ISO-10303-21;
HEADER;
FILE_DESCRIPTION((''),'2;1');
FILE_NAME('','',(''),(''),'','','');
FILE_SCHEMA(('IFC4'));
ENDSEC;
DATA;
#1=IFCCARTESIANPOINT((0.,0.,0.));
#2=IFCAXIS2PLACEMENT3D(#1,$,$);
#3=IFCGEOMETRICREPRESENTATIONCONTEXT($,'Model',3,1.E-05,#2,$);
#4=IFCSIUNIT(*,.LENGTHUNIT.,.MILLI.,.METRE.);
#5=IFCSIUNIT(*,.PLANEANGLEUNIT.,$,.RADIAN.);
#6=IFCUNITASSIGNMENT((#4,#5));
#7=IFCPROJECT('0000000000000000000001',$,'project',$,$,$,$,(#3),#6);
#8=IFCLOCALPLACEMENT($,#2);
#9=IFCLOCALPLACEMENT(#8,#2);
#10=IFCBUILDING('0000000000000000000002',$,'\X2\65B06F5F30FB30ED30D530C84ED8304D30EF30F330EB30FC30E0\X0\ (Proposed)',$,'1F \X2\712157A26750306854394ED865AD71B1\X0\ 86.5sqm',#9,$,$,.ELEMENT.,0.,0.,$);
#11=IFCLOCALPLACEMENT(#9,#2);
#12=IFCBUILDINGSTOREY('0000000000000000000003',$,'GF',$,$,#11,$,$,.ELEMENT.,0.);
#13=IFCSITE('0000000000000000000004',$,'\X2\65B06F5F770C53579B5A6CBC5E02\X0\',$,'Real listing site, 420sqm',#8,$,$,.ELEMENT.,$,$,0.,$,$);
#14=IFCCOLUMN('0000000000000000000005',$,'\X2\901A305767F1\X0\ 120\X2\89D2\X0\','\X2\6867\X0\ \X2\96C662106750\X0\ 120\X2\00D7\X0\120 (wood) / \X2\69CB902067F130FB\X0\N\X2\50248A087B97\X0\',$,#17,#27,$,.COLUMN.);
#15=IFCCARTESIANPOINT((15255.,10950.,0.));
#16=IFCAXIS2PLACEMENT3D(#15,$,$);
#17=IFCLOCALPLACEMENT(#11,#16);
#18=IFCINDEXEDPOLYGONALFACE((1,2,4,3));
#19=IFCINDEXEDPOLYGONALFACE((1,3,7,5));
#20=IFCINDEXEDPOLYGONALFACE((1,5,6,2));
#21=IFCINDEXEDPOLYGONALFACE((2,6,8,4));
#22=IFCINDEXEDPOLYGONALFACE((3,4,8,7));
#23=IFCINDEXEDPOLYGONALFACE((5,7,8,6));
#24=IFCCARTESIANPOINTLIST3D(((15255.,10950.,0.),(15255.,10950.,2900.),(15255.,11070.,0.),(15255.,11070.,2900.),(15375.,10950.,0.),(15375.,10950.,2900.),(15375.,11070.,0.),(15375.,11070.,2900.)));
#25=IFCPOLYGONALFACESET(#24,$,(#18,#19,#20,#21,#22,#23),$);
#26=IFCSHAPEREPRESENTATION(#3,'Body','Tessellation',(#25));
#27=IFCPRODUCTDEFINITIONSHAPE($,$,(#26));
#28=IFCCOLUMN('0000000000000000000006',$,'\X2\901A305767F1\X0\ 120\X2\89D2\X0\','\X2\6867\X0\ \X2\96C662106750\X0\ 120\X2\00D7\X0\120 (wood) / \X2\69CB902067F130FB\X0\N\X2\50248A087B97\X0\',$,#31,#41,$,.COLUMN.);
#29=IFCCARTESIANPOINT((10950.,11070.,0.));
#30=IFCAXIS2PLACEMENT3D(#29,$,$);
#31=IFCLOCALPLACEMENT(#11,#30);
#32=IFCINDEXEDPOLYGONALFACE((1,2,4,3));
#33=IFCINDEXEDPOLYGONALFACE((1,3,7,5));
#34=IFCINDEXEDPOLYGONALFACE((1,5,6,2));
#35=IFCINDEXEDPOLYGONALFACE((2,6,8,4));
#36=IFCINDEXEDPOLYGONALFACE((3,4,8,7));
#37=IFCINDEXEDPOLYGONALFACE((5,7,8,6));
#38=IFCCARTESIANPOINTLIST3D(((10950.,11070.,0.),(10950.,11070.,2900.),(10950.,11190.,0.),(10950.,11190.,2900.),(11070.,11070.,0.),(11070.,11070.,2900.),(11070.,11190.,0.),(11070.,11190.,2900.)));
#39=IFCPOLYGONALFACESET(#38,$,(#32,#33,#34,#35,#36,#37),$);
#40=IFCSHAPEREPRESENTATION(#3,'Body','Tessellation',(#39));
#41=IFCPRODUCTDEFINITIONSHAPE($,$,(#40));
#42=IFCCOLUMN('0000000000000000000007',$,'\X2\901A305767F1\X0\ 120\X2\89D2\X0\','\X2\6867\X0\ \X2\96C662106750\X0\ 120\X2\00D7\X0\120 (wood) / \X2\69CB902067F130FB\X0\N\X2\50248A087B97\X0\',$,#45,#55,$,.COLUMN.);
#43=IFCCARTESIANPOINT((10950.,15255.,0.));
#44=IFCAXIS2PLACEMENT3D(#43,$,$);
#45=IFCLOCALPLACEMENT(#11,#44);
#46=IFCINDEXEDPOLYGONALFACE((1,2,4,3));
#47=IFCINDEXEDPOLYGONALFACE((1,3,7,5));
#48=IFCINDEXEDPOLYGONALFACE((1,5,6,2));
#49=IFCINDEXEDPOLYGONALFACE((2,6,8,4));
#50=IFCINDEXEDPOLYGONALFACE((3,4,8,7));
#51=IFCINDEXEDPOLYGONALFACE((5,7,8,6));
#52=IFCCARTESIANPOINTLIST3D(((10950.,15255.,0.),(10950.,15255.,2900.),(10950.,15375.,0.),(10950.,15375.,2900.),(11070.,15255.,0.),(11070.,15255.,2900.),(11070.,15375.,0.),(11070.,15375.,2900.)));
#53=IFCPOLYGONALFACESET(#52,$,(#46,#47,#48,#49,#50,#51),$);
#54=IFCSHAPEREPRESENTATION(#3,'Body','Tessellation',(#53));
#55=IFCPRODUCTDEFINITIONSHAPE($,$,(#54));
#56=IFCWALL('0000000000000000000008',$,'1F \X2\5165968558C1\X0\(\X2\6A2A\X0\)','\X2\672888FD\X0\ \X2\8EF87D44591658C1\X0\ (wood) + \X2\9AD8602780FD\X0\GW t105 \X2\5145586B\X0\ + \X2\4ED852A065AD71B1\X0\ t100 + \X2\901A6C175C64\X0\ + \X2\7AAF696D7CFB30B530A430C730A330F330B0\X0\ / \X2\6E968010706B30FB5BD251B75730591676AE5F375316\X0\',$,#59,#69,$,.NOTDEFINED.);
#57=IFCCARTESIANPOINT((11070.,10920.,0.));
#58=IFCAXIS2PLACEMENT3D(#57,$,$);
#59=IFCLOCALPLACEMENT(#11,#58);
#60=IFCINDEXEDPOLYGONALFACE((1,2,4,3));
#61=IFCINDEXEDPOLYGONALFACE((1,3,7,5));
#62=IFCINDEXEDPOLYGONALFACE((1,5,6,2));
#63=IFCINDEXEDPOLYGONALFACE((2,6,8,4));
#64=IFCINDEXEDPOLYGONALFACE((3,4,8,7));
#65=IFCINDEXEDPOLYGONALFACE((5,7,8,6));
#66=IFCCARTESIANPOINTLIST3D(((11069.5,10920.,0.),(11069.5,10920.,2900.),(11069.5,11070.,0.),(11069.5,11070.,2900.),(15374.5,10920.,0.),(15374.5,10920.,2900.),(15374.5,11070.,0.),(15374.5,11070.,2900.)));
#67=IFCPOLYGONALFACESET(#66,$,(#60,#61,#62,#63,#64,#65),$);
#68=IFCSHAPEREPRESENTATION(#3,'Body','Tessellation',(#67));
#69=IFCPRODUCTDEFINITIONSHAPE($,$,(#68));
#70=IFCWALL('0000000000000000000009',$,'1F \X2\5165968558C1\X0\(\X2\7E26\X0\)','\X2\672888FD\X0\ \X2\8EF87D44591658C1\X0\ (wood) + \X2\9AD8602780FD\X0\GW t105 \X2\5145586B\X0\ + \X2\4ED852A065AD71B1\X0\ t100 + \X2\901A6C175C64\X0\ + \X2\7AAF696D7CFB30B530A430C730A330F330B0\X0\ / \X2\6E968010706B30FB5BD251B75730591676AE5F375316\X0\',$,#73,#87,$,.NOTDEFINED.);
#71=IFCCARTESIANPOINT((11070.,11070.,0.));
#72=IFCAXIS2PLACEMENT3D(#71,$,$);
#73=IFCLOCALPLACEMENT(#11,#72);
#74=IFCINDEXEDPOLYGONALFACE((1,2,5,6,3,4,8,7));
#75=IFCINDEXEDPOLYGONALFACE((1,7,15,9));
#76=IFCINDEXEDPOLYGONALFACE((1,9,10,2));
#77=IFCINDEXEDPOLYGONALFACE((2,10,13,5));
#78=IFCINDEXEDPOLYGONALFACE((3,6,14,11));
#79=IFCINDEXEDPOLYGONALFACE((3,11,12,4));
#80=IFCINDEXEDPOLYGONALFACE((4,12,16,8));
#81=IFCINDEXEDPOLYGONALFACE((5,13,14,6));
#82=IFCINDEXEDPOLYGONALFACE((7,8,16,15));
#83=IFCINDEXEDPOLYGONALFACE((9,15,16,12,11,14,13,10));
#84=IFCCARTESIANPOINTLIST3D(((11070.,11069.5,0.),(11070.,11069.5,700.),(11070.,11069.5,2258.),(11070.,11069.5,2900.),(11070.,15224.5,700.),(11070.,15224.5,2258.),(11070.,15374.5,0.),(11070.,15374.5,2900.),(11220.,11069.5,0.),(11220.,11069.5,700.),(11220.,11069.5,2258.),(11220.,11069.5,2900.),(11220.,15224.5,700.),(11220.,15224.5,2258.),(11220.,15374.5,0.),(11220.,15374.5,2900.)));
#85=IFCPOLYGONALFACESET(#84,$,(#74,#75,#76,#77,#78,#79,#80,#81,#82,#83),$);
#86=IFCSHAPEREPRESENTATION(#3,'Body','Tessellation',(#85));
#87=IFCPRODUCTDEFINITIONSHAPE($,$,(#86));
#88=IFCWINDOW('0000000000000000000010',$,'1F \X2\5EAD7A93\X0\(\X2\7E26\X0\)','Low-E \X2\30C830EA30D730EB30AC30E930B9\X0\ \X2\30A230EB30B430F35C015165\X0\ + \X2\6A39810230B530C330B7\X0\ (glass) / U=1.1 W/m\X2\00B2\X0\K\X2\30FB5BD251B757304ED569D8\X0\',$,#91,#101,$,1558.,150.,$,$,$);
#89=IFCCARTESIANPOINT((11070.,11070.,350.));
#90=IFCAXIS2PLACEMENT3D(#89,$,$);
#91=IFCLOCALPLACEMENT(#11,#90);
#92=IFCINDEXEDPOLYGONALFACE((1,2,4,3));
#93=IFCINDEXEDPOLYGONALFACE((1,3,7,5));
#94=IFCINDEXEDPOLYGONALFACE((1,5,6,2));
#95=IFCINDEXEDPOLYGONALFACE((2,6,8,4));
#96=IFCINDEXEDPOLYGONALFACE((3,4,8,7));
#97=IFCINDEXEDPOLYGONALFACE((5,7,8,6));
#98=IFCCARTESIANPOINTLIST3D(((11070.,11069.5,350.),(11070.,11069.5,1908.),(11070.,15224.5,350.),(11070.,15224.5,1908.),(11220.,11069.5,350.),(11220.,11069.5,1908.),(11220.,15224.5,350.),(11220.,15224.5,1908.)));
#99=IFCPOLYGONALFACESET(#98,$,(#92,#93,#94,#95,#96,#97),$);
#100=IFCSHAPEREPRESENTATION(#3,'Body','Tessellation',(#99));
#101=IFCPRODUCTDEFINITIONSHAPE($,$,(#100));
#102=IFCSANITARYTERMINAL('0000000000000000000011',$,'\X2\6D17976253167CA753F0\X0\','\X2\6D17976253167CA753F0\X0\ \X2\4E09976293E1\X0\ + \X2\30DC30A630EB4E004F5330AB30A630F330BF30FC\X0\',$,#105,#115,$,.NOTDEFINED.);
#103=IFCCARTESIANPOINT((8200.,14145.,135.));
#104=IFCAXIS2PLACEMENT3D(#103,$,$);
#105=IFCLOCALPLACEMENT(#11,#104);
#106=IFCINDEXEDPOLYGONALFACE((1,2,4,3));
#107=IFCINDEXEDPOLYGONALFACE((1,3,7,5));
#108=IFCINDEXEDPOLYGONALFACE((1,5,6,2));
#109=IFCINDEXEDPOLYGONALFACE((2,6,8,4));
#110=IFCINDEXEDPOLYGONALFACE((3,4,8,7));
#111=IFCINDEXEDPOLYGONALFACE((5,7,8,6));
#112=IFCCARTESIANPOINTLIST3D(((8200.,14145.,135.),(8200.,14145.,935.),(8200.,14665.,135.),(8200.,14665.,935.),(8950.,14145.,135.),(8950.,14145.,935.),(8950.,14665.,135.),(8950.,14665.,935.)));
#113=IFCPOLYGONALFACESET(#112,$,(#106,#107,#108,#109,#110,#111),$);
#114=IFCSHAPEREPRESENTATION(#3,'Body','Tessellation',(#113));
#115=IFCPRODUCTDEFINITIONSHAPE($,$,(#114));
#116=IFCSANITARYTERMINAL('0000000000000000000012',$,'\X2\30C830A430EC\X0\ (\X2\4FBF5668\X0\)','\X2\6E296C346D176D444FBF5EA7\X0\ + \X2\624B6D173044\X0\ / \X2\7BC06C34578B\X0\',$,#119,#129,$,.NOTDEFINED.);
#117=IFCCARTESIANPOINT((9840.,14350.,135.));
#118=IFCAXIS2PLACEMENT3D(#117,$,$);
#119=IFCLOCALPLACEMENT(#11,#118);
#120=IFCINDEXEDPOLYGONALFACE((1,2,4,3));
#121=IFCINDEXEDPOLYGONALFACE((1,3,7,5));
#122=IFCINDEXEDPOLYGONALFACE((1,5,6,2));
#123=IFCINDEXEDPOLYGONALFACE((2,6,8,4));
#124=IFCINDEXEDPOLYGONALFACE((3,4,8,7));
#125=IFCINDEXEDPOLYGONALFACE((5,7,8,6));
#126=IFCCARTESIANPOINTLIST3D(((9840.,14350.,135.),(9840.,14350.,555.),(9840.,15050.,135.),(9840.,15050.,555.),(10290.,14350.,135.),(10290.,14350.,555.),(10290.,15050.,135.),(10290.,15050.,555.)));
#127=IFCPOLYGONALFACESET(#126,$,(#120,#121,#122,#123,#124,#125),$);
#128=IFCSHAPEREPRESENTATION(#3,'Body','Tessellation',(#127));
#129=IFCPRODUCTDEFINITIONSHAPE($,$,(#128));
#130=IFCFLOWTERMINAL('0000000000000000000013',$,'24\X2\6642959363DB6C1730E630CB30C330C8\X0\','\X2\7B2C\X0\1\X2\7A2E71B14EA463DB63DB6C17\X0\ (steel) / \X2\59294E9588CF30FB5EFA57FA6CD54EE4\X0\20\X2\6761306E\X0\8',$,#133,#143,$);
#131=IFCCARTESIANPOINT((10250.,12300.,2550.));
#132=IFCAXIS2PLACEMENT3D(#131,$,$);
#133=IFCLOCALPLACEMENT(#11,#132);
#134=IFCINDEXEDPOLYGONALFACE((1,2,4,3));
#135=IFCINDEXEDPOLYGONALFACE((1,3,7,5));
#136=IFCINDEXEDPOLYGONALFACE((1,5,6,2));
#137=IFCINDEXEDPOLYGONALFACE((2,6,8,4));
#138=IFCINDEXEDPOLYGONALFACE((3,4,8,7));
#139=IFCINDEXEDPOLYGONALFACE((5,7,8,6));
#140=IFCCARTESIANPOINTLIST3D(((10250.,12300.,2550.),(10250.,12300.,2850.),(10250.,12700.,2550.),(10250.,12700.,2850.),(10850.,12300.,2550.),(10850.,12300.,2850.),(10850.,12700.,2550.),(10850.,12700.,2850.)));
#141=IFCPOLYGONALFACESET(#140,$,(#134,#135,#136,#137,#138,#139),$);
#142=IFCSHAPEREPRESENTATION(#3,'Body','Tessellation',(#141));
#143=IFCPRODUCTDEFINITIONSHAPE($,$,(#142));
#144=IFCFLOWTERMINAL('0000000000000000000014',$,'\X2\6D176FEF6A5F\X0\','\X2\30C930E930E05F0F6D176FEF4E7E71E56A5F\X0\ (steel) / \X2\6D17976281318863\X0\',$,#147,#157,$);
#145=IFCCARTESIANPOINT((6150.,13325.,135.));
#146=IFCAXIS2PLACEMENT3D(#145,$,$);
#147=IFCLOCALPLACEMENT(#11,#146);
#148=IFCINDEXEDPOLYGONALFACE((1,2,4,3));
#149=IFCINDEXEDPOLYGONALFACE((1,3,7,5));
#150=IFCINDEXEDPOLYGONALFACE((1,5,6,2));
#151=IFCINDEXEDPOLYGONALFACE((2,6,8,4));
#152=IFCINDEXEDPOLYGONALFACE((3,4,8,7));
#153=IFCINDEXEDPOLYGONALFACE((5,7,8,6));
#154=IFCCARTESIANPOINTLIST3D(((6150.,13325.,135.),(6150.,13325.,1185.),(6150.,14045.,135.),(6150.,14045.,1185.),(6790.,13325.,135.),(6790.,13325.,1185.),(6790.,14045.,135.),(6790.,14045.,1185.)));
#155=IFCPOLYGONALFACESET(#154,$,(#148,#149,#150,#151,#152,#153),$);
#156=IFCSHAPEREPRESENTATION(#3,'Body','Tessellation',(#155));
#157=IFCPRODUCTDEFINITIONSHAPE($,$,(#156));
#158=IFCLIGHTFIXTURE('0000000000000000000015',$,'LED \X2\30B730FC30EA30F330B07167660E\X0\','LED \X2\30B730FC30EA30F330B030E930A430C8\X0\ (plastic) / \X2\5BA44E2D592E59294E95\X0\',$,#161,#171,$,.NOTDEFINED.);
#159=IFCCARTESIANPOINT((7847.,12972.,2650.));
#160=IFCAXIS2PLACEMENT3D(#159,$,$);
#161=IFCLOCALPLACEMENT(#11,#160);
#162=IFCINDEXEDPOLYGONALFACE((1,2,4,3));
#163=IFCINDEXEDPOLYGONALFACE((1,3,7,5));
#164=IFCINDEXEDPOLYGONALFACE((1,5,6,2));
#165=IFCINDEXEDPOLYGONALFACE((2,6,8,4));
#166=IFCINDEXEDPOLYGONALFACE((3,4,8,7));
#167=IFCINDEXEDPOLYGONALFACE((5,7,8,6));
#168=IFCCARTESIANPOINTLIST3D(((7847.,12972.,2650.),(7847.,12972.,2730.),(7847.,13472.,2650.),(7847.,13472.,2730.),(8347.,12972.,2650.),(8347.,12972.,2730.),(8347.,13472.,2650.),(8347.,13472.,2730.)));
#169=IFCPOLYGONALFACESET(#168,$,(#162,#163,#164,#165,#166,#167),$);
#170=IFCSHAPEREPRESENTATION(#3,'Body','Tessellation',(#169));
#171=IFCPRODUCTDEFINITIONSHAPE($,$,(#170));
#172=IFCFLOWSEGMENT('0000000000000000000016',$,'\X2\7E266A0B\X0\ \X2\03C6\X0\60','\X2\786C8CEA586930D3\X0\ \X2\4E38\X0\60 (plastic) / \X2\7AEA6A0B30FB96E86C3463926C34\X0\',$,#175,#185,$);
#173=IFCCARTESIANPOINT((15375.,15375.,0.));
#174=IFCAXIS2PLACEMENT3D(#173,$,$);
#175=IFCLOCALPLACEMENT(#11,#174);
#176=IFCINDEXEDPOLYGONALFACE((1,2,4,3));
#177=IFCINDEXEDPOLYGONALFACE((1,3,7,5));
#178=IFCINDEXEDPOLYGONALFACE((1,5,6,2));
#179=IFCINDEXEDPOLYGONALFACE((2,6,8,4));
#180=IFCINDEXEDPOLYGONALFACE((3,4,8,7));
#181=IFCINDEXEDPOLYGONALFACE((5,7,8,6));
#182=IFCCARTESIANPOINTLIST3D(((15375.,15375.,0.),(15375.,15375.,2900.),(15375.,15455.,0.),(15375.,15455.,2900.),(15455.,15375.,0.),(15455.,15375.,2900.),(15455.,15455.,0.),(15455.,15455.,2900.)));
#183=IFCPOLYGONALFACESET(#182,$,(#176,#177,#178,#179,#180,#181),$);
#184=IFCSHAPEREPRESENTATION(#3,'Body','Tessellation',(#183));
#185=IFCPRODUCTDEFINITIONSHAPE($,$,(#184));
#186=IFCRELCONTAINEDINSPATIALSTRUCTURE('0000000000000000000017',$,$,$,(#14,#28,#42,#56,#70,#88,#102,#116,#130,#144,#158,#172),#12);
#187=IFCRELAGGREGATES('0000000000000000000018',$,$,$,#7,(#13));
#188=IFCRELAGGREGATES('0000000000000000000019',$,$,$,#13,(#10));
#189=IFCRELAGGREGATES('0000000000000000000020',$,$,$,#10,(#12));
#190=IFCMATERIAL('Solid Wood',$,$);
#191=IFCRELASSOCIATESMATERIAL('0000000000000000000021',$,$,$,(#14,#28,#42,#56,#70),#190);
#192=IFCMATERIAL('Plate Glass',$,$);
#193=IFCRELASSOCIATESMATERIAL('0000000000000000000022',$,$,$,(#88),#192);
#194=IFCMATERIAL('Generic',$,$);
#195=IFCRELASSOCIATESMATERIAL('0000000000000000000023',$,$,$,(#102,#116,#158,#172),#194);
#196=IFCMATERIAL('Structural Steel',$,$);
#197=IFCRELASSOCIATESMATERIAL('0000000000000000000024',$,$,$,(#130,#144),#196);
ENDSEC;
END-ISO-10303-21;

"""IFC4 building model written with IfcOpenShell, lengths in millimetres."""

from ifc_helpers import new_model, si_unit, frame, frame_2d, origin, place, context, project, spatial, rectangle, extrude, material, element, fill, save


model = new_model("IFC4")

# Units and contexts
model_context = context("Model", 3, precision=1e-05, world=origin())
ifc_project = project(units=[si_unit("LENGTHUNIT", "METRE", prefix="MILLI"), si_unit("PLANEANGLEUNIT", "RADIAN")], contexts=[model_context])

# Site, building, storey
site_placement = place(None, origin())
site = spatial("IfcSite", under=ifc_project, at=site_placement, Name="新潟県南魚沼市", ObjectType="Real listing site, 420sqm", CompositionType="ELEMENT", RefElevation=0.0)
building_placement = place(site_placement, origin())
building = spatial("IfcBuilding", under=site, at=building_placement, Name="新潟・ロフト付きワンルーム (Proposed)", ObjectType="1F 無垢材と吹付断熱 86.5sqm", CompositionType="ELEMENT", ElevationOfRefHeight=0.0, ElevationOfTerrain=0.0)
storey_placement = place(building_placement, origin())
storey = spatial("IfcBuildingStorey", under=building, at=storey_placement, Name="GF", CompositionType="ELEMENT", Elevation=0.0)

# Columns
ifc_material_1 = material(Name="Solid Wood")
column_1_placement = place(storey_placement, frame((15255.0, 10950.0, 0.0)))
element("IfcColumn", 1, at=column_1_placement, inside=storey, material=ifc_material_1, Name="通し柱 120角", Description="桧 集成材 120×120 (wood) / 構造柱・N値計算", PredefinedType="COLUMN", context=model_context, shape_type="SweptSolid", body=[
    extrude(rectangle(XDim=120.0, YDim=120.0, at=frame_2d((60.0, 60.0))), frame((15255.0, 10950.0, 0.0)), (0.0, 0.0, 1.0), 2900.0),
])
column_2_placement = place(storey_placement, frame((10950.0, 11070.0, 0.0)))
element("IfcColumn", 2, at=column_2_placement, inside=storey, material=ifc_material_1, Name="通し柱 120角", Description="桧 集成材 120×120 (wood) / 構造柱・N値計算", PredefinedType="COLUMN", context=model_context, shape_type="SweptSolid", body=[
    extrude(rectangle(XDim=120.0, YDim=120.0, at=frame_2d((60.0, 60.0))), frame((10950.0, 11070.0, 0.0)), (0.0, 0.0, 1.0), 2900.0),
])
column_3_placement = place(storey_placement, frame((10950.0, 15255.0, 0.0)))
element("IfcColumn", 3, at=column_3_placement, inside=storey, material=ifc_material_1, Name="通し柱 120角", Description="桧 集成材 120×120 (wood) / 構造柱・N値計算", PredefinedType="COLUMN", context=model_context, shape_type="SweptSolid", body=[
    extrude(rectangle(XDim=120.0, YDim=120.0, at=frame_2d((60.0, 60.0))), frame((10950.0, 15255.0, 0.0)), (0.0, 0.0, 1.0), 2900.0),
])

# Wall
wall_1_placement = place(storey_placement, frame((11070.0, 10920.0, 0.0)))
element("IfcWall", 4, at=wall_1_placement, inside=storey, material=ifc_material_1, Name="1F 入隅壁(横)", Description="木製 軸組外壁 (wood) + 高性能GW t105 充填 + 付加断熱 t100 + 通気層 + 窯業系サイディング / 準耐火・寒冷地外皮強化", PredefinedType="NOTDEFINED", context=model_context, shape_type="SweptSolid", body=[
    extrude(rectangle(XDim=4305.0, YDim=150.0, at=frame_2d((2152.0, 75.0))), frame((11070.0, 10920.0, 0.0)), (0.0, 0.0, 1.0), 2900.0),
])

# Wall, opening, window
wall_2_placement = place(storey_placement, frame((11070.0, 11070.0, 0.0)))
wall_2 = element("IfcWall", 5, at=wall_2_placement, inside=storey, material=ifc_material_1, Name="1F 入隅壁(縦)", Description="木製 軸組外壁 (wood) + 高性能GW t105 充填 + 付加断熱 t100 + 通気層 + 窯業系サイディング / 準耐火・寒冷地外皮強化", PredefinedType="NOTDEFINED", context=model_context, shape_type="SweptSolid", body=[
    extrude(rectangle(XDim=150.0, YDim=4305.0, at=frame_2d((75.0, 2152.0))), frame((11070.0, 11070.0, 0.0)), (0.0, 0.0, 1.0), 2900.0),
])
opening_placement = place(storey_placement, frame((11070.0, 11070.0, 350.0)))
opening = element("IfcOpeningElement", 6, at=opening_placement, cuts=wall_2, PredefinedType="NOTDEFINED", context=model_context, shape_type="SweptSolid", body=[
    extrude(rectangle(XDim=150.0, YDim=4155.0, at=frame_2d((75.0, 2077.0))), frame((11070.0, 11070.0, 350.0)), (0.0, 0.0, 1.0), 1558.0),
])
ifc_material_2 = material(Name="Plate Glass")
window_placement = place(storey_placement, frame((11070.0, 11070.0, 350.0)))
window = element("IfcWindow", 7, at=window_placement, inside=storey, material=ifc_material_2, Name="1F 庭窓(縦)", Description="Low-E トリプルガラス アルゴン封入 + 樹脂サッシ (glass) / U=1.1 W/m²K・寒冷地仕様", OverallHeight=1558.0, OverallWidth=150.0, context=model_context, shape_type="SweptSolid", body=[
    extrude(rectangle(XDim=150.0, YDim=4155.0, at=frame_2d((75.0, 2077.0))), frame((11070.0, 11070.0, 350.0)), (0.0, 0.0, 1.0), 1558.0),
])
fill(opening, window)

# Sanitary terminals
ifc_material_3 = material(Name="Generic")
sanitary_terminal_1_placement = place(storey_placement, frame((8200.0, 14145.0, 135.0)))
element("IfcSanitaryTerminal", 8, at=sanitary_terminal_1_placement, inside=storey, material=ifc_material_3, Name="洗面化粧台", Description="洗面化粧台 三面鏡 + ボウル一体カウンター", PredefinedType="NOTDEFINED", context=model_context, shape_type="SweptSolid", body=[
    extrude(rectangle(XDim=750.0, YDim=520.0, at=frame_2d((375.0, 260.0))), frame((8200.0, 14145.0, 135.0)), (0.0, 0.0, 1.0), 800.0),
])
sanitary_terminal_2_placement = place(storey_placement, frame((9840.0, 14350.0, 135.0)))
element("IfcSanitaryTerminal", 9, at=sanitary_terminal_2_placement, inside=storey, material=ifc_material_3, Name="トイレ (便器)", Description="温水洗浄便座 + 手洗い / 節水型", PredefinedType="NOTDEFINED", context=model_context, shape_type="SweptSolid", body=[
    extrude(rectangle(XDim=450.0, YDim=700.0, at=frame_2d((225.0, 350.0))), frame((9840.0, 14350.0, 135.0)), (0.0, 0.0, 1.0), 420.0),
])

# Flow terminals
ifc_material_4 = material(Name="Structural Steel")
flow_terminal_1_placement = place(storey_placement, frame((10250.0, 12300.0, 2550.0)))
element("IfcFlowTerminal", 10, at=flow_terminal_1_placement, inside=storey, material=ifc_material_4, Name="24時間換気ユニット", Description="第1種熱交換換気 (steel) / 天井裏・建基法令20条の8", context=model_context, shape_type="SweptSolid", body=[
    extrude(rectangle(XDim=600.0, YDim=400.0, at=frame_2d((300.0, 200.0))), frame((10250.0, 12300.0, 2550.0)), (0.0, 0.0, 1.0), 300.0),
])
flow_terminal_2_placement = place(storey_placement, frame((6150.0, 13325.0, 135.0)))
element("IfcFlowTerminal", 11, at=flow_terminal_2_placement, inside=storey, material=ifc_material_4, Name="洗濯機", Description="ドラム式洗濯乾燥機 (steel) / 洗面脱衣", context=model_context, shape_type="SweptSolid", body=[
    extrude(rectangle(XDim=640.0, YDim=720.0, at=frame_2d((320.0, 360.0))), frame((6150.0, 13325.0, 135.0)), (0.0, 0.0, 1.0), 1050.0),
])

# Light fixture
light_fixture_placement = place(storey_placement, frame((7847.0, 12972.0, 2650.0)))
element("IfcLightFixture", 12, at=light_fixture_placement, inside=storey, material=ifc_material_3, Name="LED シーリング照明", Description="LED シーリングライト (plastic) / 室中央天井", PredefinedType="NOTDEFINED", context=model_context, shape_type="SweptSolid", body=[
    extrude(rectangle(XDim=500.0, YDim=500.0, at=frame_2d((250.0, 250.0))), frame((7847.0, 12972.0, 2650.0)), (0.0, 0.0, 1.0), 80.0),
])

# Flow segment
flow_segment_placement = place(storey_placement, frame((15375.0, 15375.0, 0.0)))
element("IfcFlowSegment", 13, at=flow_segment_placement, inside=storey, material=ifc_material_3, Name="縦樋 φ60", Description="硬質塩ビ 丸60 (plastic) / 竪樋・雨水排水", context=model_context, shape_type="SweptSolid", body=[
    extrude(rectangle(XDim=80.0, YDim=80.0, at=frame_2d((40.0, 40.0))), frame((15375.0, 15375.0, 0.0)), (0.0, 0.0, 1.0), 2900.0),
])

save(model, "model.ifc")
